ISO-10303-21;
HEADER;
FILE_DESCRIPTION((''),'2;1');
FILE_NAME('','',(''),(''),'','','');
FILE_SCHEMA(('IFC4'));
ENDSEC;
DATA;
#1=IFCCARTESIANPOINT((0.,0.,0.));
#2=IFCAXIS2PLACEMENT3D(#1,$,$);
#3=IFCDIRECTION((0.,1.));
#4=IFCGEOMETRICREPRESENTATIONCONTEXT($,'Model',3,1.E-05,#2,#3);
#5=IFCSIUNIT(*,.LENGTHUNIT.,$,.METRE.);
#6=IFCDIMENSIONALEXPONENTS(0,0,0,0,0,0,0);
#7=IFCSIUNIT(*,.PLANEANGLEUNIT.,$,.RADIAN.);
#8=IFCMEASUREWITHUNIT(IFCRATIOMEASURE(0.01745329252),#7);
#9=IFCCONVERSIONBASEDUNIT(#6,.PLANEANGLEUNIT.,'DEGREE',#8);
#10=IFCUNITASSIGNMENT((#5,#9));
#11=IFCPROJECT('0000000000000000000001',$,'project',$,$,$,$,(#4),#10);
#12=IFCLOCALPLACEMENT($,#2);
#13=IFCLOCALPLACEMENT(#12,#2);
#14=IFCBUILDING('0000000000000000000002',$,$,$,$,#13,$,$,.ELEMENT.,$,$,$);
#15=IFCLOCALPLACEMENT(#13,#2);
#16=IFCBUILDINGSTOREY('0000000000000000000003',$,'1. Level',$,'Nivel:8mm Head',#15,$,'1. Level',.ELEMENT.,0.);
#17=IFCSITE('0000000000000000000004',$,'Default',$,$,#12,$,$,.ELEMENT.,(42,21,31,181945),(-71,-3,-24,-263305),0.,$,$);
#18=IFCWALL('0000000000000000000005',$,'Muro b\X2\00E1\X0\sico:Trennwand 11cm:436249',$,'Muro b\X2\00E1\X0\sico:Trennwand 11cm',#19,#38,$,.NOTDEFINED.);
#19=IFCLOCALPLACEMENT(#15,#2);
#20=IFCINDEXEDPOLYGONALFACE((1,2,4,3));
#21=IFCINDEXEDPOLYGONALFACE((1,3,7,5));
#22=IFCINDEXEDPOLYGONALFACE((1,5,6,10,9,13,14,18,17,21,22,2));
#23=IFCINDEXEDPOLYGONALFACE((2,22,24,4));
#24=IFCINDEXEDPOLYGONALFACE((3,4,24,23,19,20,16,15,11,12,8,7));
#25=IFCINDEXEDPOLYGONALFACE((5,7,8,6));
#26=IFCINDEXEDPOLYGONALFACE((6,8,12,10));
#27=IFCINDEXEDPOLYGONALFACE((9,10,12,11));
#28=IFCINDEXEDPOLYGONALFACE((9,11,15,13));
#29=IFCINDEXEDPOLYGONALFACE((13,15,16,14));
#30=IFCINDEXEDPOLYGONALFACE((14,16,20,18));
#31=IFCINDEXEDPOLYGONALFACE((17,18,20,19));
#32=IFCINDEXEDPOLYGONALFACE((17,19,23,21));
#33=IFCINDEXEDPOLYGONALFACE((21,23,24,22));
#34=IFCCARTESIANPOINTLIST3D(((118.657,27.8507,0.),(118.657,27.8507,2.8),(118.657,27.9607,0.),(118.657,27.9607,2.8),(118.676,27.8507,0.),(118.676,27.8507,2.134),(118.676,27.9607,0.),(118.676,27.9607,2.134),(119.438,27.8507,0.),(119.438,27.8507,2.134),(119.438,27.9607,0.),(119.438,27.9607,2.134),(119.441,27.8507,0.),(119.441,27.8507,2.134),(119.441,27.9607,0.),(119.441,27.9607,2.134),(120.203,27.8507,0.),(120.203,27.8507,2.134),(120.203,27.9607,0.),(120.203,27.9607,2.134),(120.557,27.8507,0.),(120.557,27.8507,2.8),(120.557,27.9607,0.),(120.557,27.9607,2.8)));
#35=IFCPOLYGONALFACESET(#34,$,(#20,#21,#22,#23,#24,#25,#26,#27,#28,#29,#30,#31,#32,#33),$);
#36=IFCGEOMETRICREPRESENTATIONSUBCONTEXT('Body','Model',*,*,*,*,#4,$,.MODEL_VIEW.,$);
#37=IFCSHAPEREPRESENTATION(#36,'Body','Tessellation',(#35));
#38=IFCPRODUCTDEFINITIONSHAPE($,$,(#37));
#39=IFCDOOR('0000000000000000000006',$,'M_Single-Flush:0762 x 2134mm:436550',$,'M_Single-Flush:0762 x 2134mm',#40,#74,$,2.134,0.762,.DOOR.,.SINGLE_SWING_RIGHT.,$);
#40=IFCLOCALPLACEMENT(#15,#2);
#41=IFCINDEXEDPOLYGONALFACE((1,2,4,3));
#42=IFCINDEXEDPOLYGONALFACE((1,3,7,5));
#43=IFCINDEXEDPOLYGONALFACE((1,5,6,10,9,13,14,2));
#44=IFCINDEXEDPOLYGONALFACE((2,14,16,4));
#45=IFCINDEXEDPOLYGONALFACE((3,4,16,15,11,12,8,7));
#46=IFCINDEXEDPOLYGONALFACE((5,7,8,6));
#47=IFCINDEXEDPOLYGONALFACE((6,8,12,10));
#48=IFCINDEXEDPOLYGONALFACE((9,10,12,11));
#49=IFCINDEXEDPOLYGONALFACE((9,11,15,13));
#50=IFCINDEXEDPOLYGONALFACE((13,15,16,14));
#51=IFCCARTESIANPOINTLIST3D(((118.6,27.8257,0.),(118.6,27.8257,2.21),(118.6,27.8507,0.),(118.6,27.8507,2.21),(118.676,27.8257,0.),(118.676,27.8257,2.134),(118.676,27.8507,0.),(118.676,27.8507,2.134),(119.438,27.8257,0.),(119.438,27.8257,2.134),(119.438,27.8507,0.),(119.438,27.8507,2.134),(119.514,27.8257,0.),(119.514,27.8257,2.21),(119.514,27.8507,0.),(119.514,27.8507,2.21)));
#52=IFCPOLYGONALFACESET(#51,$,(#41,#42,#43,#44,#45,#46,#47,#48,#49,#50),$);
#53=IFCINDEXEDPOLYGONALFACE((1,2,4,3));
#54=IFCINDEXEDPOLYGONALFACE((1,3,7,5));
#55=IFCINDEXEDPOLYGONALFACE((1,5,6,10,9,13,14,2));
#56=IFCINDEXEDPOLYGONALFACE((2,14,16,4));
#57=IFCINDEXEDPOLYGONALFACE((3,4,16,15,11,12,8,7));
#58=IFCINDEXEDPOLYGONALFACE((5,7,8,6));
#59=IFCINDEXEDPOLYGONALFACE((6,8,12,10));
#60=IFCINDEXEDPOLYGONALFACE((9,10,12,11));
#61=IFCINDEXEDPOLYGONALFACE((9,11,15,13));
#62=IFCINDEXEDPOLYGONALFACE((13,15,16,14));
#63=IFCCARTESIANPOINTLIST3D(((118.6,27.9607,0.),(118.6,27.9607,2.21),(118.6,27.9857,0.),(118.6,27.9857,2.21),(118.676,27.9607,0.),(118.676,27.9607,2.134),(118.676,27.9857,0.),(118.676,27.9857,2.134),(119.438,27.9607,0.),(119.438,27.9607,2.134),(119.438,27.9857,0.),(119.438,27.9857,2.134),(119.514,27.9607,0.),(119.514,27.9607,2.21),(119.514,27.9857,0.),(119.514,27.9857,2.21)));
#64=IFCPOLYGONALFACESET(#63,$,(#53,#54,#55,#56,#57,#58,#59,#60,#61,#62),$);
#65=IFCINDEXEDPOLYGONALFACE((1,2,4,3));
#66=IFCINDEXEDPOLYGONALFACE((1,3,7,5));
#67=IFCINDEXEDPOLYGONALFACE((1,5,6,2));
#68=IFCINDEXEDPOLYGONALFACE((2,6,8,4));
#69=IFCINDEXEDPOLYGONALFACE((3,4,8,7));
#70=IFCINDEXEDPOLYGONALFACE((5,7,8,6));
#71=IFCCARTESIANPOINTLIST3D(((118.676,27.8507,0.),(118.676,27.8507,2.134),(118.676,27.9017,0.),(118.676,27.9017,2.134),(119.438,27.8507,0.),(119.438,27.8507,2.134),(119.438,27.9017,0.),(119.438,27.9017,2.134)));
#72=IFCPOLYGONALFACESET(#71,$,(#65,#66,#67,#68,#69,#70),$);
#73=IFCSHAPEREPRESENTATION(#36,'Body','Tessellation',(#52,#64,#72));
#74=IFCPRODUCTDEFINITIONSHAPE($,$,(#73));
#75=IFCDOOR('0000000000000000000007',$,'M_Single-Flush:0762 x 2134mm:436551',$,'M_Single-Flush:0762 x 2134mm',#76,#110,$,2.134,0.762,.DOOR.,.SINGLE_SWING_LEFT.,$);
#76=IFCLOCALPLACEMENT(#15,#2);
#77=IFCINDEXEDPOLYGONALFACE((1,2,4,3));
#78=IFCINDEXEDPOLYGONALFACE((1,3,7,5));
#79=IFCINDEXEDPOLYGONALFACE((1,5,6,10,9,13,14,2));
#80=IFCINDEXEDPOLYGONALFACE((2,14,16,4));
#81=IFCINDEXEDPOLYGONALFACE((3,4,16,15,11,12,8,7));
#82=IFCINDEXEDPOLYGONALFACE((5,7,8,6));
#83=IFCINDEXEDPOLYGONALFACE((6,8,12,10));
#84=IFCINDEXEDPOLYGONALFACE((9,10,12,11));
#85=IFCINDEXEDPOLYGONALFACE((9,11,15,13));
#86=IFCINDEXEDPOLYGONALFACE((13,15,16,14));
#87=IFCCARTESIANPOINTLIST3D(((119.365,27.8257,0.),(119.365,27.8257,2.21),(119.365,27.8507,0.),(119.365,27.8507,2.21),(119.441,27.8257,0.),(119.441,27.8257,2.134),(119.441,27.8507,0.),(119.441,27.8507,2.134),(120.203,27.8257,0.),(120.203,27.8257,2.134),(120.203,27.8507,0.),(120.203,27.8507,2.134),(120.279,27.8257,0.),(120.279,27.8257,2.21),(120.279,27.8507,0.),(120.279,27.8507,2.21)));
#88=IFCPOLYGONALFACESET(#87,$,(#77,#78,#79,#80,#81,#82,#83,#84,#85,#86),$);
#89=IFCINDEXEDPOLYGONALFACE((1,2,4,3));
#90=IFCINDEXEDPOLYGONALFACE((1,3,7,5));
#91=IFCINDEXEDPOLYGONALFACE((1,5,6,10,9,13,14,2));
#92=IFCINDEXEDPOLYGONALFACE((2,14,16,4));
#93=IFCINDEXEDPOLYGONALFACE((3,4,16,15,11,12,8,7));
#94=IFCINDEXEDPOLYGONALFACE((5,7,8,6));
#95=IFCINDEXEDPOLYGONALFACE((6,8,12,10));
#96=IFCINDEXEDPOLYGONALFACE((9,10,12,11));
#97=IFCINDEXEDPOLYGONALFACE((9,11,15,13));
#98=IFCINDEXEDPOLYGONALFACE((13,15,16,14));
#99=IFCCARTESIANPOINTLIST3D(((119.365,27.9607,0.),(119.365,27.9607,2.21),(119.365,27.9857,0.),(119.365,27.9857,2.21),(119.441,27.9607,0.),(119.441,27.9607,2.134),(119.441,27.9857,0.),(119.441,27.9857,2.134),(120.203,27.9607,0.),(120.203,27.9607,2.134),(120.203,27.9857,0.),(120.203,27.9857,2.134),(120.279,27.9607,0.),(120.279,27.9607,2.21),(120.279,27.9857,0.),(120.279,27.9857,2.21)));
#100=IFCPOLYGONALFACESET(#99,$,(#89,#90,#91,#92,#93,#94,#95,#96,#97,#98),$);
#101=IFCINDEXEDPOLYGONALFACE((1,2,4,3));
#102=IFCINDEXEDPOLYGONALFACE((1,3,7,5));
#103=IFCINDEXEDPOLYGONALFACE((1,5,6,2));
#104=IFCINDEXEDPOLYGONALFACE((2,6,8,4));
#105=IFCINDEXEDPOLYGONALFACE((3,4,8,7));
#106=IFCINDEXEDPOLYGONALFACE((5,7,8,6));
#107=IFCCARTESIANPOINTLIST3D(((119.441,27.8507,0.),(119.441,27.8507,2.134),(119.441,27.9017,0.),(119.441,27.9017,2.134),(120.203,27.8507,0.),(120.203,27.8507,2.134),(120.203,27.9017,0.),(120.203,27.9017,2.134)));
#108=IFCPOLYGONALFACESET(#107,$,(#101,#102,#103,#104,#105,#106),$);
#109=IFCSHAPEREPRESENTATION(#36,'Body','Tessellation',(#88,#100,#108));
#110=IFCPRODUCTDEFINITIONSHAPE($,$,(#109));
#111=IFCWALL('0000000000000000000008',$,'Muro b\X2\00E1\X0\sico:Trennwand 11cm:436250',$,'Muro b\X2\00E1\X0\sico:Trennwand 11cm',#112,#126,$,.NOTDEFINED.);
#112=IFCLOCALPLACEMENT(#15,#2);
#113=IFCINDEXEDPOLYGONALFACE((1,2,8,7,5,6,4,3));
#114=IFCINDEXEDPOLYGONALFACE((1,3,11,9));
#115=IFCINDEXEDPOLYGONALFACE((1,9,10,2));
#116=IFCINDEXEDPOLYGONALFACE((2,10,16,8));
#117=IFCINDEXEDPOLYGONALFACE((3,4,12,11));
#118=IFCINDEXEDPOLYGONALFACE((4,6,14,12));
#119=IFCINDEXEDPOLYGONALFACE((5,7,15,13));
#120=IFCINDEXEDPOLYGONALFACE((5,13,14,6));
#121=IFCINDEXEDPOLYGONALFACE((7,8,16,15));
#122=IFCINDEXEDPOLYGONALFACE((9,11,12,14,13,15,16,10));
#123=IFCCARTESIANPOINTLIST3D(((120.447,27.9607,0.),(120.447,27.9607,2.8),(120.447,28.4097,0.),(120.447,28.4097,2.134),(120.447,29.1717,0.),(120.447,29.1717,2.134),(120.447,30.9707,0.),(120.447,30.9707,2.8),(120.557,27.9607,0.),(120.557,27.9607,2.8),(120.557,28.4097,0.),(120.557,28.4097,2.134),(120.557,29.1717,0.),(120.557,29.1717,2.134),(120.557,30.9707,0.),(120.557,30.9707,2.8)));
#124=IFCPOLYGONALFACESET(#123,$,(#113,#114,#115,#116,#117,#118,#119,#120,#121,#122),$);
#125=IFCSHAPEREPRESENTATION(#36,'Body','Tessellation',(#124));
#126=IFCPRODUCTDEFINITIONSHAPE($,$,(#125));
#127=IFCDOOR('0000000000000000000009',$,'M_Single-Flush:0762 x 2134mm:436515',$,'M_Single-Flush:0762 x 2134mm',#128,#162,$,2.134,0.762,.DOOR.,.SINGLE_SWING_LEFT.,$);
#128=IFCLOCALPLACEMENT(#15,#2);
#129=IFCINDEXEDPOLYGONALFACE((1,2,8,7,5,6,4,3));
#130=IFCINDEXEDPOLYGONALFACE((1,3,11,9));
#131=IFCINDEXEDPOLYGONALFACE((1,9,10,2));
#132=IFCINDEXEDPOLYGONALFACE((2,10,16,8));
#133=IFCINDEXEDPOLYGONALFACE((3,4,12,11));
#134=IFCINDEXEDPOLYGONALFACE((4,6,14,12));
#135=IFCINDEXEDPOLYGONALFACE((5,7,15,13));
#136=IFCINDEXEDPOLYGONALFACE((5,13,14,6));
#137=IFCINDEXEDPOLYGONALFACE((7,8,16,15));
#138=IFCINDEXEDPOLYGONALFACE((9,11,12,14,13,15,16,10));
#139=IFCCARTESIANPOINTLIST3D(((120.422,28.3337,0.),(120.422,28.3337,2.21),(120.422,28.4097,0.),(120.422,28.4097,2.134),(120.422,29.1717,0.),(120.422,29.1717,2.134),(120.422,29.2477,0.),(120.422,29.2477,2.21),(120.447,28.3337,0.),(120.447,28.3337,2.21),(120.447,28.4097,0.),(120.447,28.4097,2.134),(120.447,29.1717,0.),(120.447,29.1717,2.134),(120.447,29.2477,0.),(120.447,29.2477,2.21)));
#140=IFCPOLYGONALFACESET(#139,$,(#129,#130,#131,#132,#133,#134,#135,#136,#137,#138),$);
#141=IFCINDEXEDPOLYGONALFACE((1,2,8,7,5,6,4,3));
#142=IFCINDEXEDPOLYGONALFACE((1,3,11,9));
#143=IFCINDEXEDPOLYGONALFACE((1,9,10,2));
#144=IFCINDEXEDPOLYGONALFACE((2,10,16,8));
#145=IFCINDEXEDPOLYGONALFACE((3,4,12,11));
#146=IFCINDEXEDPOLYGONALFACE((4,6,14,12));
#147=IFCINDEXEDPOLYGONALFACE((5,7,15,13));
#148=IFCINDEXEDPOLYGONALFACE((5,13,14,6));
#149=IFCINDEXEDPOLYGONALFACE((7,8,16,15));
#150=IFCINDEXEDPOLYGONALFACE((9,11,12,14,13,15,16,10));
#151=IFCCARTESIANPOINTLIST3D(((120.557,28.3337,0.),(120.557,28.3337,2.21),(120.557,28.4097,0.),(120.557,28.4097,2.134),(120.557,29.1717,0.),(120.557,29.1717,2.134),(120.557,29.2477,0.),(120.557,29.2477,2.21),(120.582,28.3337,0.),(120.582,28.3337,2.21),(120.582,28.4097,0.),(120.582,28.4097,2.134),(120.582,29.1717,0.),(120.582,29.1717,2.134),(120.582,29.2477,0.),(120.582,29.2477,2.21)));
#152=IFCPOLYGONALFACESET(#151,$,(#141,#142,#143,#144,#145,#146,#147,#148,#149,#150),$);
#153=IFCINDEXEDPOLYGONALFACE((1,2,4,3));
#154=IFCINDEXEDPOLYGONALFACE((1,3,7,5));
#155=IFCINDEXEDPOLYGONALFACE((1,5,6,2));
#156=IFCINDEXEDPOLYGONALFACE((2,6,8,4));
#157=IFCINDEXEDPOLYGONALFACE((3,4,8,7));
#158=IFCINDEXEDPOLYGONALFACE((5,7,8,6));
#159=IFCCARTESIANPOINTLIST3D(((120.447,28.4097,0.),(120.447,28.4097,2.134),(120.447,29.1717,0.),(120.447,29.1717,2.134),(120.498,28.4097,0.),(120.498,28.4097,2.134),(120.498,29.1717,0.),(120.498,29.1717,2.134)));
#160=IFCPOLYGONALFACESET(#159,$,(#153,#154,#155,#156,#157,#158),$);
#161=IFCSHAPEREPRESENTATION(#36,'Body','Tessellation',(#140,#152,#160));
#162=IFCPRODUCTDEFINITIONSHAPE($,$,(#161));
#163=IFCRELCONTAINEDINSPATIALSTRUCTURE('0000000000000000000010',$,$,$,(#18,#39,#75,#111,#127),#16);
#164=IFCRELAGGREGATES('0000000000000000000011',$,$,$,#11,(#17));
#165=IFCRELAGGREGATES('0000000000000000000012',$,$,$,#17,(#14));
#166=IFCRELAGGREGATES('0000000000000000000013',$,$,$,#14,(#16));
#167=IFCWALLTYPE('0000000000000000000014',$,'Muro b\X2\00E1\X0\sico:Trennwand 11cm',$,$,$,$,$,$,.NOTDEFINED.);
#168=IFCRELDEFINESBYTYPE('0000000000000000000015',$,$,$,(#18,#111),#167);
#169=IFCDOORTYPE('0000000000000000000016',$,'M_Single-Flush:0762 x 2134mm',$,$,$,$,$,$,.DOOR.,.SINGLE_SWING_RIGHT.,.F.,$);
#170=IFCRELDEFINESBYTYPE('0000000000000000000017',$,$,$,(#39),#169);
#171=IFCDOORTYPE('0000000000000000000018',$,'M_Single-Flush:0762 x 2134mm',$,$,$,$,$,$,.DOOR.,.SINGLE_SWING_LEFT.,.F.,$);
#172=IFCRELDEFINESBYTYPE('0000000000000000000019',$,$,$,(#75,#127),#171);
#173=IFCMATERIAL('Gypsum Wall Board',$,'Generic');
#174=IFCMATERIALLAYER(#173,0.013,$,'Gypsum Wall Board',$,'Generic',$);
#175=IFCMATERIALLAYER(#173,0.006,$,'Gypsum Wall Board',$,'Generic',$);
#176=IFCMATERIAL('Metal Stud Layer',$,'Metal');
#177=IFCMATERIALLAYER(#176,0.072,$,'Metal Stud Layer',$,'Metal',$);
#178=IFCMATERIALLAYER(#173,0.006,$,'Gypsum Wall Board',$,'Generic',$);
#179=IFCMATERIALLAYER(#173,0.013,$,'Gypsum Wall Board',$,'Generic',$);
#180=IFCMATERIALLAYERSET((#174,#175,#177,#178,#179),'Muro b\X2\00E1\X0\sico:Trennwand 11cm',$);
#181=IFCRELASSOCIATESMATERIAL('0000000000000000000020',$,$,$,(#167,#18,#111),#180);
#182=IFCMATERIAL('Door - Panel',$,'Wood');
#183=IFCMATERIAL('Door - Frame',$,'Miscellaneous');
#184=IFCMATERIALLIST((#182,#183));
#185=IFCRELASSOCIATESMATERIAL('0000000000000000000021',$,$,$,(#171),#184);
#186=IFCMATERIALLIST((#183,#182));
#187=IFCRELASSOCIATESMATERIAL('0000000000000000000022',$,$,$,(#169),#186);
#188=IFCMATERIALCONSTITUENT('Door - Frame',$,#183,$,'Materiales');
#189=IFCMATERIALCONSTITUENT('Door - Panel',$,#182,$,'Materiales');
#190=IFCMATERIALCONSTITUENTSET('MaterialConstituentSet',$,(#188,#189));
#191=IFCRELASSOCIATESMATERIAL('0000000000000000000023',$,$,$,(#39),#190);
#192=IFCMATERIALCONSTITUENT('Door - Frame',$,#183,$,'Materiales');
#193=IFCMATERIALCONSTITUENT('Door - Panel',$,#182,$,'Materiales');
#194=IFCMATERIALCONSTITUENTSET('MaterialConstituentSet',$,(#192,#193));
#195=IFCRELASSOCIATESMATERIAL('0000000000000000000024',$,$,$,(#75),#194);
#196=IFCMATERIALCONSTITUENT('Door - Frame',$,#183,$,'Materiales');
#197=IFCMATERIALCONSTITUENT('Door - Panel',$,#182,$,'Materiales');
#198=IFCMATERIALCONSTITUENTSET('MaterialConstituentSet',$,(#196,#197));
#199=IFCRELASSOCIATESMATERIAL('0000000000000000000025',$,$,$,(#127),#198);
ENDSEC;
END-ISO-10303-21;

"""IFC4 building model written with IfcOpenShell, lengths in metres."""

from ifc_helpers import new_model, entity, si_unit, converted_unit, direction, frame, frame_2d, origin, origin_2d_with_axis, place, context, subcontext, project, spatial, polyline, rectangle, outline, extrude, source, transform, mapped, material, material_list, layer, layer_set, layer_usage, constituent, constituent_set, type_object, type_shapes, element, fill, save


model = new_model("IFC4")

# Units and contexts
model_context = context("Model", 3, precision=1e-05, world=origin(), true_north=direction((0.0, 1.0)))
body_context = subcontext(model_context, "Body", "Model", "MODEL_VIEW")
ifc_project = project(units=[si_unit("LENGTHUNIT", "METRE"), converted_unit("PLANEANGLEUNIT", "DEGREE", entity("IfcRatioMeasure", 0.01745329252), si_unit("PLANEANGLEUNIT", "RADIAN"), dimensions=[0, 0, 0, 0, 0, 0, 0])], contexts=[model_context])

# Site, building, storey
site_placement = place(None, origin())
site = spatial("IfcSite", under=ifc_project, at=site_placement, Name="Default", CompositionType="ELEMENT", RefLatitude=(42, 21, 31, 181945), RefLongitude=(-71, -3, -24, -263305), RefElevation=0.0)
building_placement = place(site_placement, origin())
building = spatial("IfcBuilding", under=site, at=building_placement, CompositionType="ELEMENT")
storey_placement = place(building_placement, origin())
storey = spatial("IfcBuildingStorey", under=building, at=storey_placement, Name="1. Level", ObjectType="Nivel:8mm Head", LongName="1. Level", CompositionType="ELEMENT", Elevation=0.0)

# Shared definitions
ifc_material_1 = material(Name="Gypsum Wall Board", Category="Generic")
ifc_layer_1 = layer(ifc_material_1, 0.013, Name="Gypsum Wall Board", Category="Generic")
ifc_layer_2 = layer(ifc_material_1, 0.006, Name="Gypsum Wall Board", Category="Generic")
ifc_material_2 = material(Name="Metal Stud Layer", Category="Metal")
ifc_layer_3 = layer(ifc_material_2, 0.072, Name="Metal Stud Layer", Category="Metal")
ifc_layer_4 = layer(ifc_material_1, 0.006, Name="Gypsum Wall Board", Category="Generic")
ifc_layer_5 = layer(ifc_material_1, 0.013, Name="Gypsum Wall Board", Category="Generic")
ifc_layer_set_1 = layer_set([ifc_layer_1, ifc_layer_2, ifc_layer_3, ifc_layer_4, ifc_layer_5], Name="Muro básico:Trennwand 11cm")
wall_type_1 = type_object("IfcWallType", Name="Muro básico:Trennwand 11cm", PredefinedType="NOTDEFINED", material=ifc_layer_set_1)
ifc_material_3 = material(Name="Door - Frame", Category="Miscellaneous")
ifc_material_4 = material(Name="Door - Panel", Category="Wood")
ifc_material_list_1 = material_list([ifc_material_4, ifc_material_3])
door_type_1 = type_object("IfcDoorType", Name="M_Single-Flush:0762 x 2134mm", OperationType="SINGLE_SWING_LEFT", ParameterTakesPrecedence=False, PredefinedType="DOOR", material=ifc_material_list_1)
shared_shape_1 = source(origin(), body_context, "Body", "SweptSolid", [
    extrude(outline(polyline([(-0.457, -1.124), (0.457, -1.124), (0.457, 1.086), (0.381, 1.086), (0.381, -1.048), (-0.381, -1.048), (-0.381, 1.086), (-0.457, 1.086), (-0.457, -1.124)])), frame((0.381, 0.135, 1.086), z_axis=(0.0, -1.0, 0.0), x_axis=(-1.0, 0.0, 0.0)), (0.0, 0.0, 1.0), 0.025),
    extrude(outline(polyline([(-1.124, -0.457), (1.086, -0.457), (1.086, -0.381), (-1.048, -0.381), (-1.048, 0.381), (1.086, 0.381), (1.086, 0.457), (-1.124, 0.457), (-1.124, -0.457)])), frame((0.381, 0.0, 1.086), z_axis=(0.0, -1.0, 0.0), x_axis=(0.0, 0.0, -1.0)), (0.0, 0.0, 1.0), 0.025),
    extrude(rectangle(XDim=0.762, YDim=0.051, at=origin_2d_with_axis()), frame((0.381, 0.0845, 0.0)), (0.0, 0.0, 1.0), 2.134),
])
type_shapes(door_type_1, [shared_shape_1])

# Wall, openings, doors
ifc_layer_usage_1 = layer_usage(ifc_layer_set_1, "AXIS2", "NEGATIVE", 0.055)
wall_1_placement = place(storey_placement, frame((118.657, 27.9057, 0.0)))
wall_1 = element("IfcWall", 1, at=wall_1_placement, inside=storey, type_object=wall_type_1, material=ifc_layer_usage_1, Name="Muro básico:Trennwand 11cm:436249", ObjectType="Muro básico:Trennwand 11cm", PredefinedType="NOTDEFINED", context=body_context, shape_type="SweptSolid", body=[
    extrude(rectangle(XDim=1.9, YDim=0.11, at=frame_2d((0.95, 0.0), x_axis=(-1.0, 0.0))), origin(), (0.0, 0.0, 1.0), 2.8),
])
opening_1_placement = place(wall_1_placement, frame((0.781, 0.055, 0.0)))
opening_1 = element("IfcOpeningElement", 2, at=opening_1_placement, cuts=wall_1, ObjectType="Opening", PredefinedType="OPENING", context=body_context, shape_type="SweptSolid", body=[
    extrude(rectangle(XDim=0.762, YDim=2.134, at=frame_2d((1.067, 0.381), x_axis=(0.0, 1.0))), frame((0.0, 0.0, 0.0), z_axis=(0.0, -1.0, 0.0), x_axis=(0.0, 0.0, 1.0)), (0.0, 0.0, 1.0), 0.11),
])
opening_2_placement = place(wall_1_placement, frame((1.546, 0.055, 0.0)))
opening_2 = element("IfcOpeningElement", 3, at=opening_2_placement, cuts=wall_1, ObjectType="Opening", PredefinedType="OPENING", context=body_context, shape_type="SweptSolid", body=[
    extrude(rectangle(XDim=0.762, YDim=2.134, at=frame_2d((1.067, 0.381), x_axis=(0.0, -1.0))), frame((0.0, 0.0, 0.0), z_axis=(0.0, -1.0, 0.0), x_axis=(0.0, 0.0, 1.0)), (0.0, 0.0, 1.0), 0.11),
])
ifc_constituent_1 = constituent(ifc_material_3, Name="Door - Frame", Category="Materiales")
ifc_constituent_2 = constituent(ifc_material_4, Name="Door - Panel", Category="Materiales")
ifc_constituent_set_1 = constituent_set(constituents=[ifc_constituent_1, ifc_constituent_2], Name="MaterialConstituentSet")
ifc_material_list_2 = material_list([ifc_material_3, ifc_material_4])
door_type_2 = type_object("IfcDoorType", Name="M_Single-Flush:0762 x 2134mm", OperationType="SINGLE_SWING_RIGHT", ParameterTakesPrecedence=False, PredefinedType="DOOR", material=ifc_material_list_2)
shared_shape_2 = source(origin(), body_context, "Body", "SweptSolid", [
    extrude(outline(polyline([(-0.457, -1.124), (0.457, -1.124), (0.457, 1.086), (0.381, 1.086), (0.381, -1.048), (-0.381, -1.048), (-0.381, 1.086), (-0.457, 1.086), (-0.457, -1.124)])), frame((0.381, 0.11, 1.086), z_axis=(0.0, 1.0, 0.0), x_axis=(1.0, 0.0, 0.0)), (0.0, 0.0, 1.0), 0.025),
    extrude(outline(polyline([(-1.124, -0.457), (1.086, -0.457), (1.086, -0.381), (-1.048, -0.381), (-1.048, 0.381), (1.086, 0.381), (1.086, 0.457), (-1.124, 0.457), (-1.124, -0.457)])), frame((0.381, -0.025, 1.086), z_axis=(0.0, 1.0, 0.0), x_axis=(0.0, 0.0, -1.0)), (0.0, 0.0, 1.0), 0.025),
    extrude(rectangle(XDim=0.051, YDim=0.762, at=origin_2d_with_axis()), frame((0.381, 0.0845, 0.0), z_axis=(0.0, 0.0, 1.0), x_axis=(0.0, 1.0, 0.0)), (0.0, 0.0, 1.0), 2.134),
])
type_shapes(door_type_2, [shared_shape_2])
door_1_placement = place(opening_1_placement, frame((0.0, 0.0, 0.0), z_axis=(0.0, 0.0, 1.0), x_axis=(-1.0, 0.0, 0.0)))
door_1 = element("IfcDoor", 4, at=door_1_placement, inside=storey, type_object=door_type_2, material=ifc_constituent_set_1, Name="M_Single-Flush:0762 x 2134mm:436550", ObjectType="M_Single-Flush:0762 x 2134mm", OperationType="SINGLE_SWING_RIGHT", OverallHeight=2.134, OverallWidth=0.762, PredefinedType="DOOR", context=body_context, shape_type="MappedRepresentation", body=[
    mapped(shared_shape_2, transform((0.0, 0.0, 0.0), scale=1.0)),
])
fill(opening_1, door_1)
ifc_constituent_3 = constituent(ifc_material_3, Name="Door - Frame", Category="Materiales")
ifc_constituent_4 = constituent(ifc_material_4, Name="Door - Panel", Category="Materiales")
ifc_constituent_set_2 = constituent_set(constituents=[ifc_constituent_3, ifc_constituent_4], Name="MaterialConstituentSet")
door_2_placement = place(opening_2_placement, frame((0.0, 0.0, 0.0), z_axis=(0.0, 0.0, 1.0), x_axis=(-1.0, 0.0, 0.0)))
door_2 = element("IfcDoor", 5, at=door_2_placement, inside=storey, type_object=door_type_1, material=ifc_constituent_set_2, Name="M_Single-Flush:0762 x 2134mm:436551", ObjectType="M_Single-Flush:0762 x 2134mm", OperationType="SINGLE_SWING_LEFT", OverallHeight=2.134, OverallWidth=0.762, PredefinedType="DOOR", context=body_context, shape_type="MappedRepresentation", body=[
    mapped(shared_shape_1, transform((0.0, 0.0, 0.0), scale=1.0)),
])
fill(opening_2, door_2)

# Wall, opening, door
ifc_layer_usage_2 = layer_usage(ifc_layer_set_1, "AXIS2", "NEGATIVE", 0.055)
wall_2_placement = place(storey_placement, frame((120.502, 27.9607, 0.0), z_axis=(0.0, 0.0, 1.0), x_axis=(0.0, 1.0, 0.0)))
wall_2 = element("IfcWall", 6, at=wall_2_placement, inside=storey, type_object=wall_type_1, material=ifc_layer_usage_2, Name="Muro básico:Trennwand 11cm:436250", ObjectType="Muro básico:Trennwand 11cm", PredefinedType="NOTDEFINED", context=body_context, shape_type="SweptSolid", body=[
    extrude(rectangle(XDim=3.01, YDim=0.11, at=frame_2d((1.505, 0.0), x_axis=(-1.0, 0.0))), origin(), (0.0, 0.0, 1.0), 2.8),
])
opening_3_placement = place(wall_2_placement, frame((0.449, -0.055, 0.0)))
opening_3 = element("IfcOpeningElement", 7, at=opening_3_placement, cuts=wall_2, ObjectType="Opening", PredefinedType="OPENING", context=body_context, shape_type="SweptSolid", body=[
    extrude(rectangle(XDim=0.762, YDim=2.134, at=frame_2d((1.067, 0.381), x_axis=(0.0, -1.0))), frame((0.0, 0.0, 0.0), z_axis=(0.0, 1.0, 0.0), x_axis=(0.0, 0.0, 1.0)), (0.0, 0.0, 1.0), 0.11),
])
ifc_constituent_5 = constituent(ifc_material_3, Name="Door - Frame", Category="Materiales")
ifc_constituent_6 = constituent(ifc_material_4, Name="Door - Panel", Category="Materiales")
ifc_constituent_set_3 = constituent_set(constituents=[ifc_constituent_5, ifc_constituent_6], Name="MaterialConstituentSet")
door_3_placement = place(opening_3_placement, origin())
door_3 = element("IfcDoor", 8, at=door_3_placement, inside=storey, type_object=door_type_1, material=ifc_constituent_set_3, Name="M_Single-Flush:0762 x 2134mm:436515", ObjectType="M_Single-Flush:0762 x 2134mm", OperationType="SINGLE_SWING_LEFT", OverallHeight=2.134, OverallWidth=0.762, PredefinedType="DOOR", context=body_context, shape_type="MappedRepresentation", body=[
    mapped(shared_shape_1, transform((0.0, 0.0, 0.0), scale=1.0)),
])
fill(opening_3, door_3)

save(model, "model.ifc")
